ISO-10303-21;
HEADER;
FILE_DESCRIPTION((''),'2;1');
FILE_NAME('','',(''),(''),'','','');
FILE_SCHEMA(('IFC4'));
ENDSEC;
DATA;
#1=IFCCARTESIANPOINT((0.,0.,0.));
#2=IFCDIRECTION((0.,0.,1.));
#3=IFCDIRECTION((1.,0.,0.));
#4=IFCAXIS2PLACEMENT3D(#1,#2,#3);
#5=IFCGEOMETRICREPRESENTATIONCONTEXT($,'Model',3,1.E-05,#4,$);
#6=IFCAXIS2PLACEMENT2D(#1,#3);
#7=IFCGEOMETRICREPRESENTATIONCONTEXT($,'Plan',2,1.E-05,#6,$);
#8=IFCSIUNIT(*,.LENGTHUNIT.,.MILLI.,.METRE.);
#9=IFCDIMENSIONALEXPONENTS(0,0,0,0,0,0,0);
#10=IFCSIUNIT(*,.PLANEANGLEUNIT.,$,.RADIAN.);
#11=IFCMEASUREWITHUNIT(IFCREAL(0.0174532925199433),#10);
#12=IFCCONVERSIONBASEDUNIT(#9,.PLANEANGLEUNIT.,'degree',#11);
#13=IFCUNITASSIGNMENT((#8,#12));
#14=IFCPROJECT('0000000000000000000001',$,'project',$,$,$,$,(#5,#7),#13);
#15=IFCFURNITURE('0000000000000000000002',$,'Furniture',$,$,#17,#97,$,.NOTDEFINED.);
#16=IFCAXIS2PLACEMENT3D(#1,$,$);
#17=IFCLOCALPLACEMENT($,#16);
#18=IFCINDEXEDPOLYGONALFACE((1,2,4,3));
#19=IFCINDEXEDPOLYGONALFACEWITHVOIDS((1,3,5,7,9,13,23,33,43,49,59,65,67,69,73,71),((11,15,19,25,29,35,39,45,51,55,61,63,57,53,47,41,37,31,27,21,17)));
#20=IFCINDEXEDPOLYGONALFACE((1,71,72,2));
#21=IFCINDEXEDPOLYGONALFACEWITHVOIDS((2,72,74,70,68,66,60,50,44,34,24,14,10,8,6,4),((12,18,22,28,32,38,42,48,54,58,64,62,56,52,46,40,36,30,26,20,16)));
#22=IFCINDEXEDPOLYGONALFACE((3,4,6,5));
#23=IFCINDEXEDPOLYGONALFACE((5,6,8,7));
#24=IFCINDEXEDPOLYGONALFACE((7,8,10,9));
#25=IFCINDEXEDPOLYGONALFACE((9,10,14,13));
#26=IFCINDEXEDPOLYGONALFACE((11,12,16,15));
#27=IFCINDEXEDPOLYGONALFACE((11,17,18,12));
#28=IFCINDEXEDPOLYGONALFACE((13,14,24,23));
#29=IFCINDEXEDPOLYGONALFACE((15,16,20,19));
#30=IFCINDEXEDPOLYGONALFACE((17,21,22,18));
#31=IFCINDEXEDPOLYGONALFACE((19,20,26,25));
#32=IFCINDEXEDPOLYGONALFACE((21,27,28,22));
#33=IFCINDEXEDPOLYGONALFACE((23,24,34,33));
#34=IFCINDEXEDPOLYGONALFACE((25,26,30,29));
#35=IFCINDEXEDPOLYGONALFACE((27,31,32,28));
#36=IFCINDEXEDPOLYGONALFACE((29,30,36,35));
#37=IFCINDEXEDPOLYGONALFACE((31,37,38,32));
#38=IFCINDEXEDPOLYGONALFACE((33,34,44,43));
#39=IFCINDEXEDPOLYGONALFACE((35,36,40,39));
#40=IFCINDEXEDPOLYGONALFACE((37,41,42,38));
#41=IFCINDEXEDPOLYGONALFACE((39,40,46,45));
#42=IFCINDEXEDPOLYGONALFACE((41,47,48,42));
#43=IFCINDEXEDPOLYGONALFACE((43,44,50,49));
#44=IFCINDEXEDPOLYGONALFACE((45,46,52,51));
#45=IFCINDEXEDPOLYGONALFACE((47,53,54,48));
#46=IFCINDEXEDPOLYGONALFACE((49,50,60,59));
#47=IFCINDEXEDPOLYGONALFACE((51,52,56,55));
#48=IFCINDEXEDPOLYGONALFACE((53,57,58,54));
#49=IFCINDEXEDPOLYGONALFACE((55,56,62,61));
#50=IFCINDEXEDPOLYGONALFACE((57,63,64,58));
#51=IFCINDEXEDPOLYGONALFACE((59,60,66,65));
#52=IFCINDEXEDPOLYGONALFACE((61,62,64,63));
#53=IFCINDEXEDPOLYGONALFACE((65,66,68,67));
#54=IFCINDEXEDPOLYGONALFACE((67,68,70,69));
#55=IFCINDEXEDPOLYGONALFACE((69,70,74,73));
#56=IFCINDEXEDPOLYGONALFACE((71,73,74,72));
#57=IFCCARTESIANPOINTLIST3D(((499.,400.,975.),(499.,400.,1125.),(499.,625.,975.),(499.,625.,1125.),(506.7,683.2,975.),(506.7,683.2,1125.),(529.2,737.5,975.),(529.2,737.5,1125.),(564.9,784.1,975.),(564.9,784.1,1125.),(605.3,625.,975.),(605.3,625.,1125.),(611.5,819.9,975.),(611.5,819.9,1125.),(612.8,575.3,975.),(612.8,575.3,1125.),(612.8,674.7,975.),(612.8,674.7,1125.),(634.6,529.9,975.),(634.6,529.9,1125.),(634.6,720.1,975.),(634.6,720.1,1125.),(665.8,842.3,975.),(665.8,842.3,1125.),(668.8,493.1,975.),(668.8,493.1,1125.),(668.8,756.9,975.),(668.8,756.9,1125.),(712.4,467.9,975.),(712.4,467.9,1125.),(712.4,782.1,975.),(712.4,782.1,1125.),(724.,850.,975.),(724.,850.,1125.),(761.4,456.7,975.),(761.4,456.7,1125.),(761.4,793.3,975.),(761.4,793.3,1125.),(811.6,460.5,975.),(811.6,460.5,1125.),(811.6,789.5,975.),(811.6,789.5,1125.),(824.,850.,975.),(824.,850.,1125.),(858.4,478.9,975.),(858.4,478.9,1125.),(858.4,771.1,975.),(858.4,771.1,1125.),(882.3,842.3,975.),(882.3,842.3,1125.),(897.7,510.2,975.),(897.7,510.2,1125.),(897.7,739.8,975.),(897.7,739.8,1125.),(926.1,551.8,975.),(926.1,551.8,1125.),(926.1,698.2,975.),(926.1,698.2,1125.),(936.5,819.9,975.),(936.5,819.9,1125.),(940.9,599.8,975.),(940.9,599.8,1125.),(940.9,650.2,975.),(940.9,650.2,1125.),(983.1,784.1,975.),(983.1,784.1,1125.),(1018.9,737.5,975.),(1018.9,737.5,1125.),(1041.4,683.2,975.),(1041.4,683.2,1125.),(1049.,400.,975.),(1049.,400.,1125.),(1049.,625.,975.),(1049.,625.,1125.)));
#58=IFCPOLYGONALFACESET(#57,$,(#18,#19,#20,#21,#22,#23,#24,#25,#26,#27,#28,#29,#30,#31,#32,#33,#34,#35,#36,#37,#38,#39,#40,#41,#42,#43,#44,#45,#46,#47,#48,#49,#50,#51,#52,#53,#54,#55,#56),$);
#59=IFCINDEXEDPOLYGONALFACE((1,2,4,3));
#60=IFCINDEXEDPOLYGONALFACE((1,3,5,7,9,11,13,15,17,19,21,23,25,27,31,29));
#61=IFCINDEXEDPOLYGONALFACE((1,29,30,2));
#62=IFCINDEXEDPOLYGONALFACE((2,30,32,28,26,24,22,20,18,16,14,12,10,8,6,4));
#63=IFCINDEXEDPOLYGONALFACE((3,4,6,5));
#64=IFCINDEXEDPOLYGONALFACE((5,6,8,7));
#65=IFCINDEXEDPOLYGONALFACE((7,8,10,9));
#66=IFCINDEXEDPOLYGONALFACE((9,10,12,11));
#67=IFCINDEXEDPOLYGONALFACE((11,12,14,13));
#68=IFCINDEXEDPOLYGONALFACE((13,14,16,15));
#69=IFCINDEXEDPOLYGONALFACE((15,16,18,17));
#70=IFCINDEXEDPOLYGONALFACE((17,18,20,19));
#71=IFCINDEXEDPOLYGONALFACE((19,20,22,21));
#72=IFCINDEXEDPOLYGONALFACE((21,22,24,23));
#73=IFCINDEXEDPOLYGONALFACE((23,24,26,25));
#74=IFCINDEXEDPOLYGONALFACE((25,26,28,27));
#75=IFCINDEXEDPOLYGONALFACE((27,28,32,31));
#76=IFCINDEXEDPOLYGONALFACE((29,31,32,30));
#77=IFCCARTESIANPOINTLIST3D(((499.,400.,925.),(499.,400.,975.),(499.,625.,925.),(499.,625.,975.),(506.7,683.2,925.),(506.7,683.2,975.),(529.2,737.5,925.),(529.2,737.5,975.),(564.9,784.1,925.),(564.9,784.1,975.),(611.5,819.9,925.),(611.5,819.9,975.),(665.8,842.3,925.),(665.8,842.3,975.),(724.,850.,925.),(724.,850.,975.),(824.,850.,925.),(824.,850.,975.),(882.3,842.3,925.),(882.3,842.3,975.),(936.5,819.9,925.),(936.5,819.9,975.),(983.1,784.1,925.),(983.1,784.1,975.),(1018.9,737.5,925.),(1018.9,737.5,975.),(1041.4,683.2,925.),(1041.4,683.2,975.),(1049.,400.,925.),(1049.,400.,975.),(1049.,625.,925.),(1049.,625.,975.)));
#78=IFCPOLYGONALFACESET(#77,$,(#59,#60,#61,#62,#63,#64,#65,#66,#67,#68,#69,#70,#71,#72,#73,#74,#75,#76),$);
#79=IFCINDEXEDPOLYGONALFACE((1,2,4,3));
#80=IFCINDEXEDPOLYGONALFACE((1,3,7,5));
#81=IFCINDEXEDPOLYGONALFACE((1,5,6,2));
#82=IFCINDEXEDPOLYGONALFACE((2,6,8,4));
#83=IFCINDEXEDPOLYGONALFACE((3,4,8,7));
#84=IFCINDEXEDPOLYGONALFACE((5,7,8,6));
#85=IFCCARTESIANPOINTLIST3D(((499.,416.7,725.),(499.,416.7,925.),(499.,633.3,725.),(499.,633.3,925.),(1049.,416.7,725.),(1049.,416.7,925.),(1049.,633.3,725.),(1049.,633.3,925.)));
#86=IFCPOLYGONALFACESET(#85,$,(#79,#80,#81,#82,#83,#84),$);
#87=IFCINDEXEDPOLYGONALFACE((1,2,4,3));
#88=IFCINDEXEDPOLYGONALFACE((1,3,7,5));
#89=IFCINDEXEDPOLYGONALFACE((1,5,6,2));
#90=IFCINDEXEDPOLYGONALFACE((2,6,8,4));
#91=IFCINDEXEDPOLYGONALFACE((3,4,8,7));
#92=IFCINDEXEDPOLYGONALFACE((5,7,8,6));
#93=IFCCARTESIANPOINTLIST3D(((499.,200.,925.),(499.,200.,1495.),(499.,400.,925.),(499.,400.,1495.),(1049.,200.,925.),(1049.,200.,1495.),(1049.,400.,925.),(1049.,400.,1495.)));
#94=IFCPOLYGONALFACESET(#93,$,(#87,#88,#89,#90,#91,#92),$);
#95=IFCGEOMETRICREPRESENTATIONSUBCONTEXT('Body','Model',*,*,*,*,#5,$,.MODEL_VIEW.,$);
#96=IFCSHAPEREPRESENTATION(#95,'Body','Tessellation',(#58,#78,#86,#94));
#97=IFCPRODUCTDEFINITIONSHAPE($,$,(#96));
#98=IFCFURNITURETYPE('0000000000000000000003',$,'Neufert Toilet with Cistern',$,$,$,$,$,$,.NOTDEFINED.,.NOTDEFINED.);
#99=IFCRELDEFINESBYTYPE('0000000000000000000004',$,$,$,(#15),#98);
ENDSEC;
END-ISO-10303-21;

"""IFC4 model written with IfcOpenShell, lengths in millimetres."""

from ifc_helpers import new_model, entity, si_unit, converted_unit, frame, frame_2d, origin_with_axes, place, context, subcontext, project, line, arc, indexed_curve, circle_curve, outline, extrude, shape, source, transform, mapped, type_object, type_shapes, element, save


model = new_model("IFC4")

# Units and contexts
model_context = context("Model", 3, precision=1e-05, world=origin_with_axes())
plan_context_1 = context("Plan", 2, precision=1e-05, world=frame_2d((0.0, 0.0, 0.0), x_axis=(1.0, 0.0, 0.0)))
plan_context_2 = context("Plan", 2, precision=1e-05, world=frame_2d((0.0, 0.0, 0.0), x_axis=(1.0, 0.0, 0.0)))
body_context_1 = subcontext(model_context, "Body", "Model", "MODEL_VIEW")
body_context_2 = subcontext(plan_context_2, "Body", "Plan", "PLAN_VIEW")
ifc_project = project(units=[si_unit("LENGTHUNIT", "METRE", prefix="MILLI"), converted_unit("PLANEANGLEUNIT", "degree", entity("IfcReal", 0.0174532925199433), si_unit("PLANEANGLEUNIT", "RADIAN"), dimensions=[0, 0, 0, 0, 0, 0, 0])], contexts=[model_context, plan_context_1])

# Furniture
furniture_type_1 = type_object("IfcFurnitureType", Name="Neufert Toilet with Cistern", AssemblyPlace="NOTDEFINED", PredefinedType="NOTDEFINED")
shared_shape_1 = source(origin_with_axes(), body_context_1, "Body", "SweptSolid", [
    extrude(outline(indexed_curve([(-275.0, -200.0, 0.0), (-275.0, -425.0, 0.0), (-209.1, -584.1, 0.0), (-50.0, -650.0, 0.0), (50.0, -650.0, 0.0), (209.1, -584.1, 0.0), (275.0, -425.0, 0.0), (275.0, -200.0, 0.0)], segments=[line(1, 2), arc(2, 3, 4), line(4, 5), arc(5, 6, 7), line(7, 8), line(1, 8)]), holes=[circle_curve(frame_2d((0.0, -425.0)), 168.8)]), frame((0.0, 0.0, 250.0), z_axis=(0.0, 0.0, 1.0), x_axis=(1.0, 0.0, 0.0)), (0.0, 0.0, 1.0), 150.0),
    extrude(outline(indexed_curve([(-275.0, -200.0, 0.0), (-275.0, -425.0, 0.0), (-209.1, -584.1, 0.0), (-50.0, -650.0, 0.0), (50.0, -650.0, 0.0), (209.1, -584.1, 0.0), (275.0, -425.0, 0.0), (275.0, -200.0, 0.0)], segments=[line(1, 2), arc(2, 3, 4), line(4, 5), arc(5, 6, 7), line(7, 8), line(1, 8)])), frame((0.0, 0.0, 200.0), z_axis=(0.0, 0.0, 1.0), x_axis=(1.0, 0.0, 0.0)), (0.0, 0.0, 1.0), 50.0),
    extrude(outline(indexed_curve([(-275.0, -216.7, 0.0), (-275.0, -433.3, 0.0), (275.0, -433.3, 0.0), (275.0, -216.7, 0.0)], segments=[line(1, 2), line(2, 3), line(3, 4), line(4, 1)])), origin_with_axes(), (0.0, 0.0, 1.0), 200.0),
    extrude(outline(indexed_curve([(-275.0, 0.0, 0.0), (-275.0, -200.0, 0.0), (275.0, -200.0, 0.0), (275.0, 0.0, 0.0)], segments=[line(1, 2), line(2, 3), line(3, 4), line(4, 1)])), frame((0.0, 0.0, 200.0), z_axis=(0.0, 0.0, 1.0), x_axis=(1.0, 0.0, 0.0)), (0.0, 0.0, 1.0), 570.0),
])
shared_shape_2 = source(origin_with_axes(), body_context_2, "Body", "Curve2D", [
    entity("IfcIndexedPolyCurve", entity("IfcCartesianPointList2D", [[-275.0, 0.0], [-275.0, -200.0], [275.0, -200.0], [275.0, 0.0]]), [entity("IfcLineIndex", [1, 2]), entity("IfcLineIndex", [2, 3]), entity("IfcLineIndex", [3, 4]), entity("IfcLineIndex", [4, 1])]),
    entity("IfcIndexedPolyCurve", entity("IfcCartesianPointList2D", [[165.0, -200.0], [192.5, -335.0]]), [entity("IfcLineIndex", [1, 2])]),
    entity("IfcTrimmedCurve", entity("IfcEllipse", entity("IfcAxis2Placement2D", entity("IfcCartesianPoint", [0.0, -335.0]), entity("IfcDirection", [1.0, 0.0])), 192.5, 315.0), [entity("IfcCartesianPoint", [-192.5, -335.0])], [entity("IfcCartesianPoint", [192.5, -335.0])], True, "CARTESIAN"),
    entity("IfcIndexedPolyCurve", entity("IfcCartesianPointList2D", [[-165.0, -200.0], [-192.5, -335.0]]), [entity("IfcLineIndex", [1, 2])]),
    entity("IfcEllipse", entity("IfcAxis2Placement2D", entity("IfcCartesianPoint", [0.0, -452.0]), entity("IfcDirection", [1.0, 0.0])), 131.2, 157.5),
    entity("IfcIndexedPolyCurve", entity("IfcCartesianPointList2D", [[-34.4, -452.0], [-34.4, -429.5], [34.4, -429.5], [34.4, -452.0]]), [entity("IfcLineIndex", [1, 2]), entity("IfcLineIndex", [2, 3]), entity("IfcLineIndex", [3, 4])]),
    entity("IfcTrimmedCurve", entity("IfcEllipse", entity("IfcAxis2Placement2D", entity("IfcCartesianPoint", [0.0, -452.0]), entity("IfcDirection", [1.0, 0.0])), 34.4, 22.5), [entity("IfcCartesianPoint", [-34.4, -452.0])], [entity("IfcCartesianPoint", [34.4, -452.0])], True, "CARTESIAN"),
])
type_shapes(furniture_type_1, [shared_shape_1, shared_shape_2])
furniture_1_placement = place(None, frame((774.0, 200.0, 725.0), z_axis=(0.0, 0.0, 1.0), x_axis=(-1.0, 0.0, 0.0)))
element("IfcFurniture", 1, at=furniture_1_placement, type_object=furniture_type_1, Name="Furniture", PredefinedType="NOTDEFINED", shapes=[
    shape(body_context_1, "Body", "MappedRepresentation", [mapped(shared_shape_1, transform((0.0, 0.0, 0.0), x_axis=(1.0, 0.0, 0.0), y_axis=(0.0, 1.0, 0.0), z_axis=(0.0, 0.0, 1.0), scale=1.0))]),
    shape(body_context_2, "Body", "MappedRepresentation", [mapped(shared_shape_2, transform((0.0, 0.0, 0.0), x_axis=(1.0, 0.0, 0.0), y_axis=(0.0, 1.0, 0.0), z_axis=(0.0, 0.0, 1.0), scale=1.0))]),
])

save(model, "model.ifc")
